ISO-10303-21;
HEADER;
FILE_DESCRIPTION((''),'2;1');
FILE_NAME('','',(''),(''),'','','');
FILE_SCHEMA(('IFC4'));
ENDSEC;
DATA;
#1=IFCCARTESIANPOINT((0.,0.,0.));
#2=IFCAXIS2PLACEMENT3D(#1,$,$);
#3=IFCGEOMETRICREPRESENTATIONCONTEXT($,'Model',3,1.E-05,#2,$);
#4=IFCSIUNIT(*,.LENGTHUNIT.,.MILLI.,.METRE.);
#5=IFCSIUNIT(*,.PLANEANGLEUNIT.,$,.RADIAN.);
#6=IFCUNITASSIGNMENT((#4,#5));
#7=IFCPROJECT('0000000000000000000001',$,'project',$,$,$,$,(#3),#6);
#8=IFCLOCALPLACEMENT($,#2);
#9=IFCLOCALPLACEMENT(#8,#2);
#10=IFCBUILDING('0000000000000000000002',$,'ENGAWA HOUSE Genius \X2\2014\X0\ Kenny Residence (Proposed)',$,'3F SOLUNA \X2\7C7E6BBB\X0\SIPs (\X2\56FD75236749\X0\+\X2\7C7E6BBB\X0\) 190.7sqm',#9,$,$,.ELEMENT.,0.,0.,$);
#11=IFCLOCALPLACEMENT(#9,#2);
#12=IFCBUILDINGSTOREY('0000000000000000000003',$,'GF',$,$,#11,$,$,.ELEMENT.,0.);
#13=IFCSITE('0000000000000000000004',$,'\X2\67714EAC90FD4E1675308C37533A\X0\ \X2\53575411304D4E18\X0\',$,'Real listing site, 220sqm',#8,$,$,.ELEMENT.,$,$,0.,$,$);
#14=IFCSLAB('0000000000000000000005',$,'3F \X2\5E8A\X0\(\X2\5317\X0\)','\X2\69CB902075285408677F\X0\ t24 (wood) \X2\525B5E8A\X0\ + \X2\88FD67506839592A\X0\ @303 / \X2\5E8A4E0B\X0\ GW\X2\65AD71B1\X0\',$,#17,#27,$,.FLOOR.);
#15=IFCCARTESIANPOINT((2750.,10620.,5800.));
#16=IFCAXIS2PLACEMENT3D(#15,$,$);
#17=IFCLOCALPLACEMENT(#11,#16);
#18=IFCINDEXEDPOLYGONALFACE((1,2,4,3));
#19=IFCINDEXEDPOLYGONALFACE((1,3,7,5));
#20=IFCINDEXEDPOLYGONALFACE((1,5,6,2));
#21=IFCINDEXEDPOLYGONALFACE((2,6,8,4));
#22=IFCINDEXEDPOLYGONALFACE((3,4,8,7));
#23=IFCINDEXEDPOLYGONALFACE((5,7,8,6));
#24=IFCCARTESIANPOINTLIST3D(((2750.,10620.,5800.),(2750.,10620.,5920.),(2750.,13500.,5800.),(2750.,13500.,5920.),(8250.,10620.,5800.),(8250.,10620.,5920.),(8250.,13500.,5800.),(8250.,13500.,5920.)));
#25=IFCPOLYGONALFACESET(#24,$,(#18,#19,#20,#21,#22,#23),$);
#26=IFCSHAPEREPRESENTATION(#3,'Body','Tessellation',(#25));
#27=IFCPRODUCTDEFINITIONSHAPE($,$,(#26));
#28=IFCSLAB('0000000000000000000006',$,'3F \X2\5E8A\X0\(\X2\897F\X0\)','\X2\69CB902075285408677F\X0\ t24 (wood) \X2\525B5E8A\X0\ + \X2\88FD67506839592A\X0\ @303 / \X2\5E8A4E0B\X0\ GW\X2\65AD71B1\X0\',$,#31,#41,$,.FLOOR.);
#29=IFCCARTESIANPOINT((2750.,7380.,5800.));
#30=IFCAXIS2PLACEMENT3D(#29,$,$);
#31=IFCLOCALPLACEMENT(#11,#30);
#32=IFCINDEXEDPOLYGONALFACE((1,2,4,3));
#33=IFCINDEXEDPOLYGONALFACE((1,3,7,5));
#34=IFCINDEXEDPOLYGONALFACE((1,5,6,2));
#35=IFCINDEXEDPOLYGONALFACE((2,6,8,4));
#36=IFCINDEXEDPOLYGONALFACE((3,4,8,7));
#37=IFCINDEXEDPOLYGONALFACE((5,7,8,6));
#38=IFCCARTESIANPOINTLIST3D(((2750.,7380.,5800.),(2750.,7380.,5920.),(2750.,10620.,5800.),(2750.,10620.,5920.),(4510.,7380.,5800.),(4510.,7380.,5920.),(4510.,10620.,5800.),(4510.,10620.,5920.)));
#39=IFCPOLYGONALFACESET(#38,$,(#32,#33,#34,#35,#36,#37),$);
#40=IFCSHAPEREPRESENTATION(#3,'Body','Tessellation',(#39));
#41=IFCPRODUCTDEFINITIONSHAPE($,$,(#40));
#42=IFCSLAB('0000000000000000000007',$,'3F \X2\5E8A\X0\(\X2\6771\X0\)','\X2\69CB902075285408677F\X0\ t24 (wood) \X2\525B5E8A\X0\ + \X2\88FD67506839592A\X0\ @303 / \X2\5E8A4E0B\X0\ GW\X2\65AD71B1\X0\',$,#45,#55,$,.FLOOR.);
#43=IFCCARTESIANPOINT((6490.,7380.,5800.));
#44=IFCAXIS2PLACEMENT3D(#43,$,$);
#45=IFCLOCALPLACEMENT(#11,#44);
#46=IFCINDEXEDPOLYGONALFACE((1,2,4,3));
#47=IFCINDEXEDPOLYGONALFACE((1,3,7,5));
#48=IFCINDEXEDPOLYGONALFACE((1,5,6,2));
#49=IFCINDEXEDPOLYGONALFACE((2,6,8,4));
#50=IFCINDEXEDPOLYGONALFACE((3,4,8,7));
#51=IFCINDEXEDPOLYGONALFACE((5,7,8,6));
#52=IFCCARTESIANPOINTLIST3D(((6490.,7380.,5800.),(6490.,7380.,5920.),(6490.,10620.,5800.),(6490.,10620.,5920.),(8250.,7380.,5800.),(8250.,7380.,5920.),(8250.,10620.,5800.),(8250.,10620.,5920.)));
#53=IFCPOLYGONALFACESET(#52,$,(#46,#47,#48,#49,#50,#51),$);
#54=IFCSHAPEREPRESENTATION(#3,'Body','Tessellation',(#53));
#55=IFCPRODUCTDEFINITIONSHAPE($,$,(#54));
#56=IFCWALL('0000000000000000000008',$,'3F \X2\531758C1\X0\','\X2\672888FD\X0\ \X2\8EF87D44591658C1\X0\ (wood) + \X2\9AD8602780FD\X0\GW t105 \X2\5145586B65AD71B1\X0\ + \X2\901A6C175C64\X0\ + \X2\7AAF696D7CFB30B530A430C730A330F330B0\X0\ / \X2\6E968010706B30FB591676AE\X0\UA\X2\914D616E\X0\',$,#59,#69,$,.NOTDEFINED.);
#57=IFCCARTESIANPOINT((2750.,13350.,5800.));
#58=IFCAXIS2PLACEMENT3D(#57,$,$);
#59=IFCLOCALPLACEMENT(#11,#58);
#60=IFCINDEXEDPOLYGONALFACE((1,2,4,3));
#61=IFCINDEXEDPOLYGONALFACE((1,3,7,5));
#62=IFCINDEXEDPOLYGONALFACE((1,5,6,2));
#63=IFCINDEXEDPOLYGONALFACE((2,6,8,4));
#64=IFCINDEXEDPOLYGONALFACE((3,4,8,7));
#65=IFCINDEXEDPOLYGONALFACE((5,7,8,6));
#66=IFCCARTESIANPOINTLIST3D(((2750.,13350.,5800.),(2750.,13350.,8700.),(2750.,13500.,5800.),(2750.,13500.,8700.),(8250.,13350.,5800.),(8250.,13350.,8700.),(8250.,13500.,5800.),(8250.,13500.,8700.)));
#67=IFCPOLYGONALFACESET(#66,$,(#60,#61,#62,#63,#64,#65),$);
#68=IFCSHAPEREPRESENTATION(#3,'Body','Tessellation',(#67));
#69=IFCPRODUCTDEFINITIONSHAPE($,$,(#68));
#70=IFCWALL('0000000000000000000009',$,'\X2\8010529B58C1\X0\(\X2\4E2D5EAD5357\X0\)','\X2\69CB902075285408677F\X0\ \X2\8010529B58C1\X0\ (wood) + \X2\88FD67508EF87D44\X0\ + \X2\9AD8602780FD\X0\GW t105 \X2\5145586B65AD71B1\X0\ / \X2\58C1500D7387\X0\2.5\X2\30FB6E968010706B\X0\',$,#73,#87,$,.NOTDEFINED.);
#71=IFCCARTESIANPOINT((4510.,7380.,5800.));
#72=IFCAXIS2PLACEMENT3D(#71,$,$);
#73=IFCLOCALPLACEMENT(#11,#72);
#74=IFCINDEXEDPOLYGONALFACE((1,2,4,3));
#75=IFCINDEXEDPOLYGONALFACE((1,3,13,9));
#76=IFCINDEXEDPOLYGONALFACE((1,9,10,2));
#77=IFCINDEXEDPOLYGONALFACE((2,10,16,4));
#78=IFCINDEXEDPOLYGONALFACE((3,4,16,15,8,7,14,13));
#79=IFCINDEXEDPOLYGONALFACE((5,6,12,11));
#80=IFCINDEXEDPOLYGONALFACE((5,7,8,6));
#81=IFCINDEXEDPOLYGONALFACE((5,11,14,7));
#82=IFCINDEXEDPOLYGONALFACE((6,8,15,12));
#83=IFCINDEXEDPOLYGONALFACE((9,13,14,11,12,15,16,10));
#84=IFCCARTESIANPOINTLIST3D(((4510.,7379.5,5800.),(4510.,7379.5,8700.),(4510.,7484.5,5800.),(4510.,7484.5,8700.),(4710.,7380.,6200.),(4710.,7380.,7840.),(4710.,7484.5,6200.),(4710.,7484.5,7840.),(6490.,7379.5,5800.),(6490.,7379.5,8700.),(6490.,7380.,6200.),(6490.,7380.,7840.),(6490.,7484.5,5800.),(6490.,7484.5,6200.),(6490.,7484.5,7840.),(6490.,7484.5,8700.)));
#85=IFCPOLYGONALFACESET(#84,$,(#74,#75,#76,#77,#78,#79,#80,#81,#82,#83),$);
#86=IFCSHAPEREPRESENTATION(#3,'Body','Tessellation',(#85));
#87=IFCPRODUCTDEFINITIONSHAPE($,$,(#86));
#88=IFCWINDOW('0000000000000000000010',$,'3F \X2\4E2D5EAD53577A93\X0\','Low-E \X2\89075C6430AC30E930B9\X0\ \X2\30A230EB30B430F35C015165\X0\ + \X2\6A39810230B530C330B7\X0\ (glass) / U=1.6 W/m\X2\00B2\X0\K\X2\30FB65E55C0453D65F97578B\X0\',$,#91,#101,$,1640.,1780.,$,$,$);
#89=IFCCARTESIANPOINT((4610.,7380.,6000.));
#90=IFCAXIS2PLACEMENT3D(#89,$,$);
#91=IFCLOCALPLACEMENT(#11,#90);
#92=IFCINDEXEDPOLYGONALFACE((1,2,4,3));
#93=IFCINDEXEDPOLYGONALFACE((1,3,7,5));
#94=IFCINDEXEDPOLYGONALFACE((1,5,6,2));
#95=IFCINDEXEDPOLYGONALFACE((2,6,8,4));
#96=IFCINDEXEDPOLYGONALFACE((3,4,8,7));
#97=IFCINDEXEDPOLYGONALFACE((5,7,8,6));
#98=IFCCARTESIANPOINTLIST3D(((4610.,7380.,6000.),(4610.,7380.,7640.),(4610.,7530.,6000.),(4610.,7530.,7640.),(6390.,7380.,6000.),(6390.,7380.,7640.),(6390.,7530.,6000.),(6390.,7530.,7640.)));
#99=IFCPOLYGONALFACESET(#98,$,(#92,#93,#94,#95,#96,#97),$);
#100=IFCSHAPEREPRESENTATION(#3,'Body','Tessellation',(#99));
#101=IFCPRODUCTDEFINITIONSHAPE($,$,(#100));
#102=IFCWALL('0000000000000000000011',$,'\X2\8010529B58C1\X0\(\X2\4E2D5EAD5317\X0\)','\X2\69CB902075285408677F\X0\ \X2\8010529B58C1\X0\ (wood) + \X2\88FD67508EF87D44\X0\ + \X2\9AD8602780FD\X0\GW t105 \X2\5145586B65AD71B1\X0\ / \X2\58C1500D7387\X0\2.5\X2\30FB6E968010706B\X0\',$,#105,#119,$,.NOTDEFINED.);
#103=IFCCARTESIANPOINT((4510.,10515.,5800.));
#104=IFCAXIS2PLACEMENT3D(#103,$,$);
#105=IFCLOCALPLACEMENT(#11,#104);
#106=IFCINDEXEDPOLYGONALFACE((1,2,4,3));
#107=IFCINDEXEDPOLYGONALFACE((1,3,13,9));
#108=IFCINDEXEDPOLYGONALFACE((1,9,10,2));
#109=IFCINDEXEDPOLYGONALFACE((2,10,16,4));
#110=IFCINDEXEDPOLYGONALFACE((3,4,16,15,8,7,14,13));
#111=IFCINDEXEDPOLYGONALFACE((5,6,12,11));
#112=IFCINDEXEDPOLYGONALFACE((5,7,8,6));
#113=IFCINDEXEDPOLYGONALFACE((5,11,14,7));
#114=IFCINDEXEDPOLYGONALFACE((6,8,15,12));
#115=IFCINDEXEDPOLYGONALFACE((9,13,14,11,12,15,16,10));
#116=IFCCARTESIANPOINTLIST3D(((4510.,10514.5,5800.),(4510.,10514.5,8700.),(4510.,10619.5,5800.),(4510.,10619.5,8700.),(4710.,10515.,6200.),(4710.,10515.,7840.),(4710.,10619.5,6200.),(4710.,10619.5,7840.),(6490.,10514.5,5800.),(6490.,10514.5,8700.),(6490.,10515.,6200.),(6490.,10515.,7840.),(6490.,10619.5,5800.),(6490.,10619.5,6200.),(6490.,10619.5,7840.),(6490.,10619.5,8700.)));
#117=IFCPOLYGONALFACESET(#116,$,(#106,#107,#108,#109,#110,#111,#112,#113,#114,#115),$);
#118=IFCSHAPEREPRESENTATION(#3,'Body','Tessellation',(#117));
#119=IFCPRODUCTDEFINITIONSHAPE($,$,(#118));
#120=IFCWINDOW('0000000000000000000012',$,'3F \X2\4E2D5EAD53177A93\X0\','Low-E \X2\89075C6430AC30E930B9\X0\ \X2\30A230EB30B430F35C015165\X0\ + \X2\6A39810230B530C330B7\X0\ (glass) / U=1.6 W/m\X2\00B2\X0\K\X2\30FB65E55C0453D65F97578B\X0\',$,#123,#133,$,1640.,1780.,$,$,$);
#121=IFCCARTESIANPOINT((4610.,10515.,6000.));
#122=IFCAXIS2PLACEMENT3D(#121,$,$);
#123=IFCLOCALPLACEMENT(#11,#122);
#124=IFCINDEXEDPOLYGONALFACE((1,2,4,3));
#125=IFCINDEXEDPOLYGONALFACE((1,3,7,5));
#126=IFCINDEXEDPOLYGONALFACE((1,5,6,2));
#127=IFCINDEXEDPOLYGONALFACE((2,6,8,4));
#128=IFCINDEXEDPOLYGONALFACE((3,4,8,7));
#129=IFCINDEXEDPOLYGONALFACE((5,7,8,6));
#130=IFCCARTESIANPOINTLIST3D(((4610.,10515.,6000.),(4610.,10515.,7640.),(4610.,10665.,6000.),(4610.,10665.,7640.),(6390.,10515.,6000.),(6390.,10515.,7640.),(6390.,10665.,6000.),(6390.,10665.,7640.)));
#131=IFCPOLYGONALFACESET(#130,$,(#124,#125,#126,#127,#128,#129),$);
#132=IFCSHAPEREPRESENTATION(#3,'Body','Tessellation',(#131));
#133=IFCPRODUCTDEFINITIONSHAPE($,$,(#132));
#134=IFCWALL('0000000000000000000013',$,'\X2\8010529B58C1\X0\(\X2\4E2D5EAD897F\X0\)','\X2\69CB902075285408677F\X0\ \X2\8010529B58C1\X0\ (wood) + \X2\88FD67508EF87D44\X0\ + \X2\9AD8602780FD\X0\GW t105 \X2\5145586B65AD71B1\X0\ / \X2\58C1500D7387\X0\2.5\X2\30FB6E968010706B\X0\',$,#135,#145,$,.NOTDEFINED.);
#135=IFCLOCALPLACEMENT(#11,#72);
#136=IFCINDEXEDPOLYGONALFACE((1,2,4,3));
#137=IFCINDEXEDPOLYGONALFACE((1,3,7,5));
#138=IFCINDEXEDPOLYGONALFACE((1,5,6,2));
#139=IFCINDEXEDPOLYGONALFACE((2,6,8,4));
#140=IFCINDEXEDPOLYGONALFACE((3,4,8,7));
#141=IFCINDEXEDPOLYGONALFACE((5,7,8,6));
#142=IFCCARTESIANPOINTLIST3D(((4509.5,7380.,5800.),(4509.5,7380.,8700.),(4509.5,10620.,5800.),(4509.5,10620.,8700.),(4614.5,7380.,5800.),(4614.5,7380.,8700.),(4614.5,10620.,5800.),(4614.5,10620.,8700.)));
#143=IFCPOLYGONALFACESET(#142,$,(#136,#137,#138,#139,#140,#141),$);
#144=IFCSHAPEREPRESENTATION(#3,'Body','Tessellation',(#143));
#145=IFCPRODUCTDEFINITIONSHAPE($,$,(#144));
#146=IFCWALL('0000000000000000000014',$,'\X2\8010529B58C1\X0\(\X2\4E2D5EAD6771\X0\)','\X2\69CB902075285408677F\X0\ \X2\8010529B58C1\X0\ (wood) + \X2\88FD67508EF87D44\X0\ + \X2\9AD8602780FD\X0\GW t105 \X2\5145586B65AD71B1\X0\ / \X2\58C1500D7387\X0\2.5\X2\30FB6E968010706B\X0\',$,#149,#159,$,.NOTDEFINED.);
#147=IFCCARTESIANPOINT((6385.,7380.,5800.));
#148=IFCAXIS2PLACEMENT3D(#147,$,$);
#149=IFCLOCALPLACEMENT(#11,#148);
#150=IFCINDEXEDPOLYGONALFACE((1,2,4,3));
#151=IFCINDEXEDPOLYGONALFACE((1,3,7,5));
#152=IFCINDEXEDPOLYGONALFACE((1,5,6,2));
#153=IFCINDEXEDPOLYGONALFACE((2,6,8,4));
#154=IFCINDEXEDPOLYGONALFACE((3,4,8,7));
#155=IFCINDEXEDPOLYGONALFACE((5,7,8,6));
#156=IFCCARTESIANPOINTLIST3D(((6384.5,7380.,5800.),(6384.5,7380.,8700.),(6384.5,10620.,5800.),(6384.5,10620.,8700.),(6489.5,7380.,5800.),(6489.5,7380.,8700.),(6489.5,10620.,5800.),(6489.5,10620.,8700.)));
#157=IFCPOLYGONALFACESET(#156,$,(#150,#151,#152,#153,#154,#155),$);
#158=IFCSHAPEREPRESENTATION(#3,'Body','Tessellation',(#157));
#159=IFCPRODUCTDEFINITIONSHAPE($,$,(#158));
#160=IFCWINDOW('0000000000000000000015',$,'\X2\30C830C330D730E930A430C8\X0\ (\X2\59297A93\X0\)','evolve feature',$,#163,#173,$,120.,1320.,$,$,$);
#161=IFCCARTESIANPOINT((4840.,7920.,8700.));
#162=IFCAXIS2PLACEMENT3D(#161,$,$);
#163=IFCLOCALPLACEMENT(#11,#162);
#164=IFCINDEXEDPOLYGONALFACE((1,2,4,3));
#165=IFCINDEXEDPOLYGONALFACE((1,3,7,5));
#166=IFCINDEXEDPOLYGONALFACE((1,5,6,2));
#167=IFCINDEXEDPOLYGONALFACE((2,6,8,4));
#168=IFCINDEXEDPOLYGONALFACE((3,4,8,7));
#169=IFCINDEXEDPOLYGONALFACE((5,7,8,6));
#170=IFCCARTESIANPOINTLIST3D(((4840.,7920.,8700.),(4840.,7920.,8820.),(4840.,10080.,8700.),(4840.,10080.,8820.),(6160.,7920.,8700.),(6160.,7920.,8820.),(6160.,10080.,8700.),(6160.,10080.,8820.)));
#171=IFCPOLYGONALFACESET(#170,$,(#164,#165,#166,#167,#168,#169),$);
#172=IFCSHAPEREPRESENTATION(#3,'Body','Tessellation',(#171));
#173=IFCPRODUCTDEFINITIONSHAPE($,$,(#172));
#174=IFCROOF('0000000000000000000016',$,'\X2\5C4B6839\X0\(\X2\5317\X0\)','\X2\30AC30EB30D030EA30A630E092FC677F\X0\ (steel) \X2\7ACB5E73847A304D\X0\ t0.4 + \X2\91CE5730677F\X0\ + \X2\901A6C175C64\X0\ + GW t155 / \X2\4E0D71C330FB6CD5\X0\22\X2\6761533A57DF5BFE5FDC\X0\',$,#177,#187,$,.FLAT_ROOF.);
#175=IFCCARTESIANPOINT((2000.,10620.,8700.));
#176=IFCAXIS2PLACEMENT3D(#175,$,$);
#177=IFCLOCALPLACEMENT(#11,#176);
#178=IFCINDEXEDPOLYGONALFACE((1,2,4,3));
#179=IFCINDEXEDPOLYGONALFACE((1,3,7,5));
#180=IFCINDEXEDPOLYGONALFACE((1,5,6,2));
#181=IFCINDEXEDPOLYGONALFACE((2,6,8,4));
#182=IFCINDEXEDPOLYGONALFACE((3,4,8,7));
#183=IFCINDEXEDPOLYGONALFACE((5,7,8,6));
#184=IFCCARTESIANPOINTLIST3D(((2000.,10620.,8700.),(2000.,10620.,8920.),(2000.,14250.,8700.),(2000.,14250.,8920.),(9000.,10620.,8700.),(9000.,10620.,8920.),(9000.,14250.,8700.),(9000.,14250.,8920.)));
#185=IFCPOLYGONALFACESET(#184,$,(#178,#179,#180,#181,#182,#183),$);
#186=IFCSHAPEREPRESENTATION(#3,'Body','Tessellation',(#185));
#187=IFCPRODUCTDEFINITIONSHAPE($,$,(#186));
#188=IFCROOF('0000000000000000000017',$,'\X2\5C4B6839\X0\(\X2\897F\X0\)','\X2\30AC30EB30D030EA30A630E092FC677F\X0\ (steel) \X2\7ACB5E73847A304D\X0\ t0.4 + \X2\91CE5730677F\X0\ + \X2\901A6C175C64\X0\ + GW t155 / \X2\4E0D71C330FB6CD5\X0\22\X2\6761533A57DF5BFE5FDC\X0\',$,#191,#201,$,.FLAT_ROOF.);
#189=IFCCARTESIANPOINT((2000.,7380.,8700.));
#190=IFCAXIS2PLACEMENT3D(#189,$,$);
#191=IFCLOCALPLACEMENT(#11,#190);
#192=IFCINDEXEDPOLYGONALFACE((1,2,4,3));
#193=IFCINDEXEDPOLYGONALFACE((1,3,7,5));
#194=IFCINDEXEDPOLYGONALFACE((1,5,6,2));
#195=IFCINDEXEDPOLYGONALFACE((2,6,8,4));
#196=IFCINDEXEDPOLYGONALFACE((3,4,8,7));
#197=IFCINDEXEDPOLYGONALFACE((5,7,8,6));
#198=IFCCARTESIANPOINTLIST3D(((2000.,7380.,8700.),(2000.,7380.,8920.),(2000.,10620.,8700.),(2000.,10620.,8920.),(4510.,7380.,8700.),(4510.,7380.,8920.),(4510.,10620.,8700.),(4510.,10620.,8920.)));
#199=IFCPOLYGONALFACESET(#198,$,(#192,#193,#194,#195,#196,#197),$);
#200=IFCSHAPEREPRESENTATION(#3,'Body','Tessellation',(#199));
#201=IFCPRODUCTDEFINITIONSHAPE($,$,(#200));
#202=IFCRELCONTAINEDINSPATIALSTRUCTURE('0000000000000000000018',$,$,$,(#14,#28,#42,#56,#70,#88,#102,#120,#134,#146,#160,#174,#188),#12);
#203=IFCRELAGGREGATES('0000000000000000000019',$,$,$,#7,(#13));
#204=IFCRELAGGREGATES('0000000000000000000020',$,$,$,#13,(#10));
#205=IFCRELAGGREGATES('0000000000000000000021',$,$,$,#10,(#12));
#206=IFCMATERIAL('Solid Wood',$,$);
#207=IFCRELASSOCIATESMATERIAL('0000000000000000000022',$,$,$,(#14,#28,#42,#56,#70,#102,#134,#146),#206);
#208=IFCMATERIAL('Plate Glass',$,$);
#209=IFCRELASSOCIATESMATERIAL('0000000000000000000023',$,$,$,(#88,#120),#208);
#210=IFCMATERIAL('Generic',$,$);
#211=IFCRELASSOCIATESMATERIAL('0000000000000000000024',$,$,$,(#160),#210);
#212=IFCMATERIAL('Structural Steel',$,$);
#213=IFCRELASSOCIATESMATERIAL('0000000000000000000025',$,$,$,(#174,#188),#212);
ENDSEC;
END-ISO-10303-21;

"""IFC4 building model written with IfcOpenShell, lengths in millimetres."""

from ifc_helpers import new_model, si_unit, frame, frame_2d, origin, place, context, project, spatial, rectangle, extrude, material, element, fill, save


model = new_model("IFC4")

# Units and contexts
model_context = context("Model", 3, precision=1e-05, world=origin())
ifc_project = project(units=[si_unit("LENGTHUNIT", "METRE", prefix="MILLI"), si_unit("PLANEANGLEUNIT", "RADIAN")], contexts=[model_context])

# Site, building, storey
site_placement = place(None, origin())
site = spatial("IfcSite", under=ifc_project, at=site_placement, Name="東京都世田谷区 南向き丘", ObjectType="Real listing site, 220sqm", CompositionType="ELEMENT", RefElevation=0.0)
building_placement = place(site_placement, origin())
building = spatial("IfcBuilding", under=site, at=building_placement, Name="ENGAWA HOUSE Genius — Kenny Residence (Proposed)", ObjectType="3F SOLUNA 籾殻SIPs (国産杉+籾殻) 190.7sqm", CompositionType="ELEMENT", ElevationOfRefHeight=0.0, ElevationOfTerrain=0.0)
storey_placement = place(building_placement, origin())
storey = spatial("IfcBuildingStorey", under=building, at=storey_placement, Name="GF", CompositionType="ELEMENT", Elevation=0.0)

# Slabs
ifc_material_1 = material(Name="Solid Wood")
slab_1_placement = place(storey_placement, frame((2750.0, 10620.0, 5800.0)))
element("IfcSlab", 1, at=slab_1_placement, inside=storey, material=ifc_material_1, Name="3F 床(北)", Description="構造用合板 t24 (wood) 剛床 + 製材根太 @303 / 床下 GW断熱", PredefinedType="FLOOR", context=model_context, shape_type="SweptSolid", body=[
    extrude(rectangle(XDim=5500.0, YDim=2880.0, at=frame_2d((2750.0, 1440.0))), frame((2750.0, 10620.0, 5800.0)), (0.0, 0.0, 1.0), 120.0),
])
slab_2_placement = place(storey_placement, frame((2750.0, 7380.0, 5800.0)))
element("IfcSlab", 2, at=slab_2_placement, inside=storey, material=ifc_material_1, Name="3F 床(西)", Description="構造用合板 t24 (wood) 剛床 + 製材根太 @303 / 床下 GW断熱", PredefinedType="FLOOR", context=model_context, shape_type="SweptSolid", body=[
    extrude(rectangle(XDim=1760.0, YDim=3240.0, at=frame_2d((880.0, 1620.0))), frame((2750.0, 7380.0, 5800.0)), (0.0, 0.0, 1.0), 120.0),
])
slab_3_placement = place(storey_placement, frame((6490.0, 7380.0, 5800.0)))
element("IfcSlab", 3, at=slab_3_placement, inside=storey, material=ifc_material_1, Name="3F 床(東)", Description="構造用合板 t24 (wood) 剛床 + 製材根太 @303 / 床下 GW断熱", PredefinedType="FLOOR", context=model_context, shape_type="SweptSolid", body=[
    extrude(rectangle(XDim=1760.0, YDim=3240.0, at=frame_2d((880.0, 1620.0))), frame((6490.0, 7380.0, 5800.0)), (0.0, 0.0, 1.0), 120.0),
])

# Wall
wall_1_placement = place(storey_placement, frame((2750.0, 13350.0, 5800.0)))
element("IfcWall", 4, at=wall_1_placement, inside=storey, material=ifc_material_1, Name="3F 北壁", Description="木製 軸組外壁 (wood) + 高性能GW t105 充填断熱 + 通気層 + 窯業系サイディング / 準耐火・外皮UA配慮", PredefinedType="NOTDEFINED", context=model_context, shape_type="SweptSolid", body=[
    extrude(rectangle(XDim=5500.0, YDim=150.0, at=frame_2d((2750.0, 75.0))), frame((2750.0, 13350.0, 5800.0)), (0.0, 0.0, 1.0), 2900.0),
])

# Walls, openings, windows
wall_2_placement = place(storey_placement, frame((4510.0, 7380.0, 5800.0)))
wall_2 = element("IfcWall", 5, at=wall_2_placement, inside=storey, material=ifc_material_1, Name="耐力壁(中庭南)", Description="構造用合板 耐力壁 (wood) + 製材軸組 + 高性能GW t105 充填断熱 / 壁倍率2.5・準耐火", PredefinedType="NOTDEFINED", context=model_context, shape_type="SweptSolid", body=[
    extrude(rectangle(XDim=1980.0, YDim=105.0, at=frame_2d((990.0, 52.0))), frame((4510.0, 7380.0, 5800.0)), (0.0, 0.0, 1.0), 2900.0),
])
opening_1_placement = place(storey_placement, frame((4610.0, 7380.0, 6000.0)))
opening_1 = element("IfcOpeningElement", 6, at=opening_1_placement, cuts=wall_2, PredefinedType="NOTDEFINED", context=model_context, shape_type="SweptSolid", body=[
    extrude(rectangle(XDim=1780.0, YDim=150.0, at=frame_2d((890.0, 75.0))), frame((4610.0, 7380.0, 6000.0)), (0.0, 0.0, 1.0), 1640.0),
])
ifc_material_2 = material(Name="Plate Glass")
window_1_placement = place(storey_placement, frame((4610.0, 7380.0, 6000.0)))
window_1 = element("IfcWindow", 7, at=window_1_placement, inside=storey, material=ifc_material_2, Name="3F 中庭南窓", Description="Low-E 複層ガラス アルゴン封入 + 樹脂サッシ (glass) / U=1.6 W/m²K・日射取得型", OverallHeight=1640.0, OverallWidth=1780.0, context=model_context, shape_type="SweptSolid", body=[
    extrude(rectangle(XDim=1780.0, YDim=150.0, at=frame_2d((890.0, 75.0))), frame((4610.0, 7380.0, 6000.0)), (0.0, 0.0, 1.0), 1640.0),
])
fill(opening_1, window_1)
wall_3_placement = place(storey_placement, frame((4510.0, 10515.0, 5800.0)))
wall_3 = element("IfcWall", 8, at=wall_3_placement, inside=storey, material=ifc_material_1, Name="耐力壁(中庭北)", Description="構造用合板 耐力壁 (wood) + 製材軸組 + 高性能GW t105 充填断熱 / 壁倍率2.5・準耐火", PredefinedType="NOTDEFINED", context=model_context, shape_type="SweptSolid", body=[
    extrude(rectangle(XDim=1980.0, YDim=105.0, at=frame_2d((990.0, 52.0))), frame((4510.0, 10515.0, 5800.0)), (0.0, 0.0, 1.0), 2900.0),
])
opening_2_placement = place(storey_placement, frame((4610.0, 10515.0, 6000.0)))
opening_2 = element("IfcOpeningElement", 9, at=opening_2_placement, cuts=wall_3, PredefinedType="NOTDEFINED", context=model_context, shape_type="SweptSolid", body=[
    extrude(rectangle(XDim=1780.0, YDim=150.0, at=frame_2d((890.0, 75.0))), frame((4610.0, 10515.0, 6000.0)), (0.0, 0.0, 1.0), 1640.0),
])
window_2_placement = place(storey_placement, frame((4610.0, 10515.0, 6000.0)))
window_2 = element("IfcWindow", 10, at=window_2_placement, inside=storey, material=ifc_material_2, Name="3F 中庭北窓", Description="Low-E 複層ガラス アルゴン封入 + 樹脂サッシ (glass) / U=1.6 W/m²K・日射取得型", OverallHeight=1640.0, OverallWidth=1780.0, context=model_context, shape_type="SweptSolid", body=[
    extrude(rectangle(XDim=1780.0, YDim=150.0, at=frame_2d((890.0, 75.0))), frame((4610.0, 10515.0, 6000.0)), (0.0, 0.0, 1.0), 1640.0),
])
fill(opening_2, window_2)

# Walls
wall_4_placement = place(storey_placement, frame((4510.0, 7380.0, 5800.0)))
element("IfcWall", 11, at=wall_4_placement, inside=storey, material=ifc_material_1, Name="耐力壁(中庭西)", Description="構造用合板 耐力壁 (wood) + 製材軸組 + 高性能GW t105 充填断熱 / 壁倍率2.5・準耐火", PredefinedType="NOTDEFINED", context=model_context, shape_type="SweptSolid", body=[
    extrude(rectangle(XDim=105.0, YDim=3240.0, at=frame_2d((52.0, 1620.0))), frame((4510.0, 7380.0, 5800.0)), (0.0, 0.0, 1.0), 2900.0),
])
wall_5_placement = place(storey_placement, frame((6385.0, 7380.0, 5800.0)))
element("IfcWall", 12, at=wall_5_placement, inside=storey, material=ifc_material_1, Name="耐力壁(中庭東)", Description="構造用合板 耐力壁 (wood) + 製材軸組 + 高性能GW t105 充填断熱 / 壁倍率2.5・準耐火", PredefinedType="NOTDEFINED", context=model_context, shape_type="SweptSolid", body=[
    extrude(rectangle(XDim=105.0, YDim=3240.0, at=frame_2d((52.0, 1620.0))), frame((6385.0, 7380.0, 5800.0)), (0.0, 0.0, 1.0), 2900.0),
])

# Window
ifc_material_3 = material(Name="Generic")
window_3_placement = place(storey_placement, frame((4840.0, 7920.0, 8700.0)))
element("IfcWindow", 13, at=window_3_placement, inside=storey, material=ifc_material_3, Name="トップライト (天窓)", Description="evolve feature", OverallHeight=120.0, OverallWidth=1320.0, context=model_context, shape_type="SweptSolid", body=[
    extrude(rectangle(XDim=1320.0, YDim=2160.0, at=frame_2d((660.0, 1080.0))), frame((4840.0, 7920.0, 8700.0)), (0.0, 0.0, 1.0), 120.0),
])

# Roofs
ifc_material_4 = material(Name="Structural Steel")
for number, where, name in (
    (14, (2000.0, 10620.0, 8700.0), "屋根(北)"),
):
    element("IfcRoof", number, at=place(storey_placement, frame(where)), inside=storey, material=ifc_material_4, Name=name, Description="ガルバリウム鋼板 (steel) 立平葺き t0.4 + 野地板 + 通気層 + GW t155 / 不燃・法22条区域対応", PredefinedType="FLAT_ROOF", context=model_context, shape_type="SweptSolid", body=[
        extrude(rectangle(XDim=7000.0, YDim=3630.0, at=frame_2d((3500.0, 1815.0))), frame((2000.0, 10620.0, 8700.0)), (0.0, 0.0, 1.0), 220.0),
    ])
roof_1_placement = place(storey_placement, frame((2000.0, 7380.0, 8700.0)))
element("IfcRoof", 15, at=roof_1_placement, inside=storey, material=ifc_material_4, Name="屋根(西)", Description="ガルバリウム鋼板 (steel) 立平葺き t0.4 + 野地板 + 通気層 + GW t155 / 不燃・法22条区域対応", PredefinedType="FLAT_ROOF", context=model_context, shape_type="SweptSolid", body=[
    extrude(rectangle(XDim=2510.0, YDim=3240.0, at=frame_2d((1255.0, 1620.0))), frame((2000.0, 7380.0, 8700.0)), (0.0, 0.0, 1.0), 220.0),
])

save(model, "model.ifc")
